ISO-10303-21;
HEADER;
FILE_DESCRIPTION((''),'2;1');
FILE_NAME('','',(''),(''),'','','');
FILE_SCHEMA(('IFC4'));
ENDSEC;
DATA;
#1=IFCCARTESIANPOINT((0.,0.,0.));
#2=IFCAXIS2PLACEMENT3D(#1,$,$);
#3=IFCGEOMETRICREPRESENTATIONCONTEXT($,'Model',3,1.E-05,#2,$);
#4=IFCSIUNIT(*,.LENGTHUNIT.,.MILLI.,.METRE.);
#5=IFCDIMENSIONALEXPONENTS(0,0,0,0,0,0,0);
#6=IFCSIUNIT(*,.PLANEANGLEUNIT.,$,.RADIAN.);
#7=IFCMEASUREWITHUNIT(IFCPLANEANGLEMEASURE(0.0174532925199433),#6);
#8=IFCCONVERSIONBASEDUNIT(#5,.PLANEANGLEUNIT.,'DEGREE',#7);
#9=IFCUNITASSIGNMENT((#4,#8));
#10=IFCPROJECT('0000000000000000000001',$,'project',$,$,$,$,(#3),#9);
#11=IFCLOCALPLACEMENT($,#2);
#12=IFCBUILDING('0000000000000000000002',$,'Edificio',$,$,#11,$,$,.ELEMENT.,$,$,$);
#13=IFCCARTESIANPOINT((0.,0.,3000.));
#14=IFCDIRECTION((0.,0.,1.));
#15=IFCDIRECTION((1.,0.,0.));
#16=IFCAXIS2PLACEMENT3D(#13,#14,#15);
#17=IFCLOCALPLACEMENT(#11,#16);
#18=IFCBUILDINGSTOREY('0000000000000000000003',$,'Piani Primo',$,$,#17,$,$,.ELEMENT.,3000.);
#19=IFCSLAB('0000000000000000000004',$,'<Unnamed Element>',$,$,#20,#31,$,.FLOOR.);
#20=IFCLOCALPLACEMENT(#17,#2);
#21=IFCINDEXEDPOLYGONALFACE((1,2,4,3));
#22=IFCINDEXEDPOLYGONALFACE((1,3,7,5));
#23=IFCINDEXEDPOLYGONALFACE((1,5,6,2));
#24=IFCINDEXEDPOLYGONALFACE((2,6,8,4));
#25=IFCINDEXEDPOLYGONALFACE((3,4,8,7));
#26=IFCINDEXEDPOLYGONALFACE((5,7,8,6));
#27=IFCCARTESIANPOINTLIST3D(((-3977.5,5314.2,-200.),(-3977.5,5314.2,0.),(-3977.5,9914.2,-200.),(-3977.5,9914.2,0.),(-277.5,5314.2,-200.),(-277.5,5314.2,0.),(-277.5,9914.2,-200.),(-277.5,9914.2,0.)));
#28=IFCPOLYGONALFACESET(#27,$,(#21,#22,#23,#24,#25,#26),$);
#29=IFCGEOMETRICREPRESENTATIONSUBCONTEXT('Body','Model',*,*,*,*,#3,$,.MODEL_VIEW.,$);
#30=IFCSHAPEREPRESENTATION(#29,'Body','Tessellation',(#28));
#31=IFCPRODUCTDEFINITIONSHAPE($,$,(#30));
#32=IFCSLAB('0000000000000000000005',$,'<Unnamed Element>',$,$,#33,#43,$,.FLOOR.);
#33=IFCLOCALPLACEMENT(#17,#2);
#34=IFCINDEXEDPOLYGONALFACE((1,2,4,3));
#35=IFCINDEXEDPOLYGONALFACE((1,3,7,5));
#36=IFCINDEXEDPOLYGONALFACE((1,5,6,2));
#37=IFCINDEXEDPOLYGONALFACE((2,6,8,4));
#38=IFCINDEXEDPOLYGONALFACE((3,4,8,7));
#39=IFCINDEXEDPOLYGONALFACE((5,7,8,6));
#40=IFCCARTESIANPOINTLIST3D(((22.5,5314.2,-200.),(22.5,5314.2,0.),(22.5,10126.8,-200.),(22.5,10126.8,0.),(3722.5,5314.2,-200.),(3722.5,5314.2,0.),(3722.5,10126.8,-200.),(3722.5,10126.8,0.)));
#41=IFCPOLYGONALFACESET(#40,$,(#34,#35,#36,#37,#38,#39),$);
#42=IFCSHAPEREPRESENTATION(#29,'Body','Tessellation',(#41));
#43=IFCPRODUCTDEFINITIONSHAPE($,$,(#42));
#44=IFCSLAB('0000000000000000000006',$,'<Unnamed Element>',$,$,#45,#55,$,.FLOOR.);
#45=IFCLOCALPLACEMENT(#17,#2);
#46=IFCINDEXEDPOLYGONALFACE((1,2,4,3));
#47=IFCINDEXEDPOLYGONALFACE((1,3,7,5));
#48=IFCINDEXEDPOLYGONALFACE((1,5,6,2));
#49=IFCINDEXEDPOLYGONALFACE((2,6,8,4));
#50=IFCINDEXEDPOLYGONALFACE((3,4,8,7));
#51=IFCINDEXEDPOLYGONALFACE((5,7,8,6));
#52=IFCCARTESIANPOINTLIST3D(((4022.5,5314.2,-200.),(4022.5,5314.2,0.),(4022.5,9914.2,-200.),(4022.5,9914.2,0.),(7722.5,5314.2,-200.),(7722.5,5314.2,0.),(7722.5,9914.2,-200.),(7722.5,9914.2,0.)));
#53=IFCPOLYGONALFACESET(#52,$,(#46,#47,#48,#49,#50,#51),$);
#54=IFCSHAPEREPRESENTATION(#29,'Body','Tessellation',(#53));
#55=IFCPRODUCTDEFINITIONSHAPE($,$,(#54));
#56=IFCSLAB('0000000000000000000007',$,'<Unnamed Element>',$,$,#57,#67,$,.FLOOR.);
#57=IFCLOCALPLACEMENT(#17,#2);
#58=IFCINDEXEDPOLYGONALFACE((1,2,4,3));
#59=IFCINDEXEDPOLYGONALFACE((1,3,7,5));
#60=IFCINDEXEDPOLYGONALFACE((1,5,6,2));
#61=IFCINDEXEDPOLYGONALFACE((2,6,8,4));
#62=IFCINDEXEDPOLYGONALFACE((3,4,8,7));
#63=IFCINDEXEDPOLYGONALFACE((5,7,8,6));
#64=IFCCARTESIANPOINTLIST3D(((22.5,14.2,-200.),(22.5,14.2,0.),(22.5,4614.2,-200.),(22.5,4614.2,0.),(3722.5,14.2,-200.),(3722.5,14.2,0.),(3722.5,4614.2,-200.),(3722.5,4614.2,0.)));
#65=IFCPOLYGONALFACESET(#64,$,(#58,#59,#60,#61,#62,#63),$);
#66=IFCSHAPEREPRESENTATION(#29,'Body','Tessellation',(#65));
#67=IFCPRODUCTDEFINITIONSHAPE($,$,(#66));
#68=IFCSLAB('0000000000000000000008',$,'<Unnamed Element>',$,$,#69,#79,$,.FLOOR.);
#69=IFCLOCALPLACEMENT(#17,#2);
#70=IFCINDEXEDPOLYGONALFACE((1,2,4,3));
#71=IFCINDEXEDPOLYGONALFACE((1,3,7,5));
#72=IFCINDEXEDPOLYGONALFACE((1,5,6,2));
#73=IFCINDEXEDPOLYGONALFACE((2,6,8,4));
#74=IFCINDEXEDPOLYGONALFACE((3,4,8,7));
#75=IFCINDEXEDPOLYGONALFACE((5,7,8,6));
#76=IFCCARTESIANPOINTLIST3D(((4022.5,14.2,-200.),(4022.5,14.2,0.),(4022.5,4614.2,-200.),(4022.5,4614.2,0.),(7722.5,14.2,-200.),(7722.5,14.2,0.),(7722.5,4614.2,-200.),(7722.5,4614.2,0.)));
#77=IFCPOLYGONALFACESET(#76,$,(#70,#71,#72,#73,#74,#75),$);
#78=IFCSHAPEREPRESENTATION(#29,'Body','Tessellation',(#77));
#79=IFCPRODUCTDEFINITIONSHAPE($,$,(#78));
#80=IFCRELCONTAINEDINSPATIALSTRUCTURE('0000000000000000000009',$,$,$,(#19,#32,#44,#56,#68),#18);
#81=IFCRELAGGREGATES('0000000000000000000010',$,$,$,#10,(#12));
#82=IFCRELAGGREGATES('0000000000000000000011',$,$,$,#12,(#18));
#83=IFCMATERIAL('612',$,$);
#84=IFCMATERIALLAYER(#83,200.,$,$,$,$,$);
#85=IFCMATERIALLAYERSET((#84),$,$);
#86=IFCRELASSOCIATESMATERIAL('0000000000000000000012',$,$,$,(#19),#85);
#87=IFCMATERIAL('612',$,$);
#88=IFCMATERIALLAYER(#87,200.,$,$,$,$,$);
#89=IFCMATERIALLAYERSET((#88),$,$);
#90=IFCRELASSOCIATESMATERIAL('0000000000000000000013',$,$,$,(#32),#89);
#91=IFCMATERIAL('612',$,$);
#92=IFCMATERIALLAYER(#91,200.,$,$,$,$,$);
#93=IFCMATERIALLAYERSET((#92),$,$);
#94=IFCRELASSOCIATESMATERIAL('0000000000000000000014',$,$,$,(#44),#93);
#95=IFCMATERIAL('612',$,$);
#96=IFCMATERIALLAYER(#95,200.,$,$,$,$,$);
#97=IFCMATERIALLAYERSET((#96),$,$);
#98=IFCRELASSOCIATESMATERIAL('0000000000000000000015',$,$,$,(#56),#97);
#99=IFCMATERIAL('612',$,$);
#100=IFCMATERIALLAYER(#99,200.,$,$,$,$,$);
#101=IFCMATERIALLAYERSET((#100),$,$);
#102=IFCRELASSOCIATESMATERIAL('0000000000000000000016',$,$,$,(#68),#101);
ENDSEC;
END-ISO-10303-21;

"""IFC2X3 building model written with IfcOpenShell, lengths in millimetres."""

from ifc_helpers import new_model, entity, si_unit, converted_unit, frame, frame_2d, origin, origin_with_axes, place, context, subcontext, project, spatial, rectangle, extrude, material, layer, layer_set, layer_usage, element, save


model = new_model("IFC2X3")

# Units and contexts
model_context = context("Model", 3, precision=1e-05, world=origin())
body_context = subcontext(model_context, "Body", "Model", "MODEL_VIEW")
ifc_project = project(units=[si_unit("LENGTHUNIT", "METRE", prefix="MILLI"), converted_unit("PLANEANGLEUNIT", "DEGREE", entity("IfcPlaneAngleMeasure", 0.0174532925199433), si_unit("PLANEANGLEUNIT", "RADIAN"), dimensions=[0, 0, 0, 0, 0, 0, 0])], contexts=[model_context])

# Building, storey
building_placement = place(None, origin())
building = spatial("IfcBuilding", under=ifc_project, at=building_placement, Name="Edificio", CompositionType="ELEMENT")
storey_placement = place(building_placement, frame((0.0, 0.0, 3000.0), z_axis=(0.0, 0.0, 1.0), x_axis=(1.0, 0.0, 0.0)))
storey = spatial("IfcBuildingStorey", under=building, at=storey_placement, Name="Piani Primo", CompositionType="ELEMENT", Elevation=3000.0)

# Slabs
ifc_material_1 = material(Name="612")
ifc_layer_1 = layer(ifc_material_1, 200.0)
ifc_layer_set_1 = layer_set([ifc_layer_1])
ifc_layer_usage_1 = layer_usage(ifc_layer_set_1, "AXIS3", "POSITIVE", 0.0)
slab_1_placement = place(storey_placement, frame((-3977.5, 9914.2, -200.0), z_axis=(0.0, 0.0, 1.0), x_axis=(1.0, 0.0, 0.0)))
element("IfcSlab", 1, at=slab_1_placement, inside=storey, material=ifc_layer_usage_1, Name="<Unnamed Element>", PredefinedType="FLOOR", context=body_context, shape_type="SweptSolid", body=[
    extrude(rectangle(XDim=4600.0, YDim=3700.0, at=frame_2d((1850.0, -2300.0), x_axis=(0.0, -1.0))), origin_with_axes(), (0.0, 0.0, 1.0), 200.0),
])
ifc_material_2 = material(Name="612")
ifc_layer_2 = layer(ifc_material_2, 200.0)
ifc_layer_set_2 = layer_set([ifc_layer_2])
ifc_layer_usage_2 = layer_usage(ifc_layer_set_2, "AXIS3", "POSITIVE", 0.0)
slab_2_placement = place(storey_placement, frame((22.5, 10126.8, -200.0), z_axis=(0.0, 0.0, 1.0), x_axis=(1.0, 0.0, 0.0)))
element("IfcSlab", 2, at=slab_2_placement, inside=storey, material=ifc_layer_usage_2, Name="<Unnamed Element>", PredefinedType="FLOOR", context=body_context, shape_type="SweptSolid", body=[
    extrude(rectangle(XDim=4812.5, YDim=3700.0, at=frame_2d((1850.0, -2406.3), x_axis=(0.0, -1.0))), origin_with_axes(), (0.0, 0.0, 1.0), 200.0),
])
ifc_material_3 = material(Name="612")
ifc_layer_3 = layer(ifc_material_3, 200.0)
ifc_layer_set_3 = layer_set([ifc_layer_3])
ifc_layer_usage_3 = layer_usage(ifc_layer_set_3, "AXIS3", "POSITIVE", 0.0)
slab_3_placement = place(storey_placement, frame((4022.5, 9914.2, -200.0), z_axis=(0.0, 0.0, 1.0), x_axis=(1.0, 0.0, 0.0)))
element("IfcSlab", 3, at=slab_3_placement, inside=storey, material=ifc_layer_usage_3, Name="<Unnamed Element>", PredefinedType="FLOOR", context=body_context, shape_type="SweptSolid", body=[
    extrude(rectangle(XDim=4600.0, YDim=3700.0, at=frame_2d((1850.0, -2300.0), x_axis=(0.0, -1.0))), origin_with_axes(), (0.0, 0.0, 1.0), 200.0),
])
ifc_material_4 = material(Name="612")
ifc_layer_4 = layer(ifc_material_4, 200.0)
ifc_layer_set_4 = layer_set([ifc_layer_4])
ifc_layer_usage_4 = layer_usage(ifc_layer_set_4, "AXIS3", "POSITIVE", 0.0)
slab_4_placement = place(storey_placement, frame((22.5, 4614.2, -200.0), z_axis=(0.0, 0.0, 1.0), x_axis=(1.0, 0.0, 0.0)))
element("IfcSlab", 4, at=slab_4_placement, inside=storey, material=ifc_layer_usage_4, Name="<Unnamed Element>", PredefinedType="FLOOR", context=body_context, shape_type="SweptSolid", body=[
    extrude(rectangle(XDim=4600.0, YDim=3700.0, at=frame_2d((1850.0, -2300.0), x_axis=(0.0, -1.0))), origin_with_axes(), (0.0, 0.0, 1.0), 200.0),
])
ifc_material_5 = material(Name="612")
ifc_layer_5 = layer(ifc_material_5, 200.0)
ifc_layer_set_5 = layer_set([ifc_layer_5])
ifc_layer_usage_5 = layer_usage(ifc_layer_set_5, "AXIS3", "POSITIVE", 0.0)
slab_5_placement = place(storey_placement, frame((4022.5, 4614.2, -200.0), z_axis=(0.0, 0.0, 1.0), x_axis=(1.0, 0.0, 0.0)))
element("IfcSlab", 5, at=slab_5_placement, inside=storey, material=ifc_layer_usage_5, Name="<Unnamed Element>", PredefinedType="FLOOR", context=body_context, shape_type="SweptSolid", body=[
    extrude(rectangle(XDim=4600.0, YDim=3700.0, at=frame_2d((1850.0, -2300.0), x_axis=(0.0, -1.0))), origin_with_axes(), (0.0, 0.0, 1.0), 200.0),
])

save(model, "model.ifc")
